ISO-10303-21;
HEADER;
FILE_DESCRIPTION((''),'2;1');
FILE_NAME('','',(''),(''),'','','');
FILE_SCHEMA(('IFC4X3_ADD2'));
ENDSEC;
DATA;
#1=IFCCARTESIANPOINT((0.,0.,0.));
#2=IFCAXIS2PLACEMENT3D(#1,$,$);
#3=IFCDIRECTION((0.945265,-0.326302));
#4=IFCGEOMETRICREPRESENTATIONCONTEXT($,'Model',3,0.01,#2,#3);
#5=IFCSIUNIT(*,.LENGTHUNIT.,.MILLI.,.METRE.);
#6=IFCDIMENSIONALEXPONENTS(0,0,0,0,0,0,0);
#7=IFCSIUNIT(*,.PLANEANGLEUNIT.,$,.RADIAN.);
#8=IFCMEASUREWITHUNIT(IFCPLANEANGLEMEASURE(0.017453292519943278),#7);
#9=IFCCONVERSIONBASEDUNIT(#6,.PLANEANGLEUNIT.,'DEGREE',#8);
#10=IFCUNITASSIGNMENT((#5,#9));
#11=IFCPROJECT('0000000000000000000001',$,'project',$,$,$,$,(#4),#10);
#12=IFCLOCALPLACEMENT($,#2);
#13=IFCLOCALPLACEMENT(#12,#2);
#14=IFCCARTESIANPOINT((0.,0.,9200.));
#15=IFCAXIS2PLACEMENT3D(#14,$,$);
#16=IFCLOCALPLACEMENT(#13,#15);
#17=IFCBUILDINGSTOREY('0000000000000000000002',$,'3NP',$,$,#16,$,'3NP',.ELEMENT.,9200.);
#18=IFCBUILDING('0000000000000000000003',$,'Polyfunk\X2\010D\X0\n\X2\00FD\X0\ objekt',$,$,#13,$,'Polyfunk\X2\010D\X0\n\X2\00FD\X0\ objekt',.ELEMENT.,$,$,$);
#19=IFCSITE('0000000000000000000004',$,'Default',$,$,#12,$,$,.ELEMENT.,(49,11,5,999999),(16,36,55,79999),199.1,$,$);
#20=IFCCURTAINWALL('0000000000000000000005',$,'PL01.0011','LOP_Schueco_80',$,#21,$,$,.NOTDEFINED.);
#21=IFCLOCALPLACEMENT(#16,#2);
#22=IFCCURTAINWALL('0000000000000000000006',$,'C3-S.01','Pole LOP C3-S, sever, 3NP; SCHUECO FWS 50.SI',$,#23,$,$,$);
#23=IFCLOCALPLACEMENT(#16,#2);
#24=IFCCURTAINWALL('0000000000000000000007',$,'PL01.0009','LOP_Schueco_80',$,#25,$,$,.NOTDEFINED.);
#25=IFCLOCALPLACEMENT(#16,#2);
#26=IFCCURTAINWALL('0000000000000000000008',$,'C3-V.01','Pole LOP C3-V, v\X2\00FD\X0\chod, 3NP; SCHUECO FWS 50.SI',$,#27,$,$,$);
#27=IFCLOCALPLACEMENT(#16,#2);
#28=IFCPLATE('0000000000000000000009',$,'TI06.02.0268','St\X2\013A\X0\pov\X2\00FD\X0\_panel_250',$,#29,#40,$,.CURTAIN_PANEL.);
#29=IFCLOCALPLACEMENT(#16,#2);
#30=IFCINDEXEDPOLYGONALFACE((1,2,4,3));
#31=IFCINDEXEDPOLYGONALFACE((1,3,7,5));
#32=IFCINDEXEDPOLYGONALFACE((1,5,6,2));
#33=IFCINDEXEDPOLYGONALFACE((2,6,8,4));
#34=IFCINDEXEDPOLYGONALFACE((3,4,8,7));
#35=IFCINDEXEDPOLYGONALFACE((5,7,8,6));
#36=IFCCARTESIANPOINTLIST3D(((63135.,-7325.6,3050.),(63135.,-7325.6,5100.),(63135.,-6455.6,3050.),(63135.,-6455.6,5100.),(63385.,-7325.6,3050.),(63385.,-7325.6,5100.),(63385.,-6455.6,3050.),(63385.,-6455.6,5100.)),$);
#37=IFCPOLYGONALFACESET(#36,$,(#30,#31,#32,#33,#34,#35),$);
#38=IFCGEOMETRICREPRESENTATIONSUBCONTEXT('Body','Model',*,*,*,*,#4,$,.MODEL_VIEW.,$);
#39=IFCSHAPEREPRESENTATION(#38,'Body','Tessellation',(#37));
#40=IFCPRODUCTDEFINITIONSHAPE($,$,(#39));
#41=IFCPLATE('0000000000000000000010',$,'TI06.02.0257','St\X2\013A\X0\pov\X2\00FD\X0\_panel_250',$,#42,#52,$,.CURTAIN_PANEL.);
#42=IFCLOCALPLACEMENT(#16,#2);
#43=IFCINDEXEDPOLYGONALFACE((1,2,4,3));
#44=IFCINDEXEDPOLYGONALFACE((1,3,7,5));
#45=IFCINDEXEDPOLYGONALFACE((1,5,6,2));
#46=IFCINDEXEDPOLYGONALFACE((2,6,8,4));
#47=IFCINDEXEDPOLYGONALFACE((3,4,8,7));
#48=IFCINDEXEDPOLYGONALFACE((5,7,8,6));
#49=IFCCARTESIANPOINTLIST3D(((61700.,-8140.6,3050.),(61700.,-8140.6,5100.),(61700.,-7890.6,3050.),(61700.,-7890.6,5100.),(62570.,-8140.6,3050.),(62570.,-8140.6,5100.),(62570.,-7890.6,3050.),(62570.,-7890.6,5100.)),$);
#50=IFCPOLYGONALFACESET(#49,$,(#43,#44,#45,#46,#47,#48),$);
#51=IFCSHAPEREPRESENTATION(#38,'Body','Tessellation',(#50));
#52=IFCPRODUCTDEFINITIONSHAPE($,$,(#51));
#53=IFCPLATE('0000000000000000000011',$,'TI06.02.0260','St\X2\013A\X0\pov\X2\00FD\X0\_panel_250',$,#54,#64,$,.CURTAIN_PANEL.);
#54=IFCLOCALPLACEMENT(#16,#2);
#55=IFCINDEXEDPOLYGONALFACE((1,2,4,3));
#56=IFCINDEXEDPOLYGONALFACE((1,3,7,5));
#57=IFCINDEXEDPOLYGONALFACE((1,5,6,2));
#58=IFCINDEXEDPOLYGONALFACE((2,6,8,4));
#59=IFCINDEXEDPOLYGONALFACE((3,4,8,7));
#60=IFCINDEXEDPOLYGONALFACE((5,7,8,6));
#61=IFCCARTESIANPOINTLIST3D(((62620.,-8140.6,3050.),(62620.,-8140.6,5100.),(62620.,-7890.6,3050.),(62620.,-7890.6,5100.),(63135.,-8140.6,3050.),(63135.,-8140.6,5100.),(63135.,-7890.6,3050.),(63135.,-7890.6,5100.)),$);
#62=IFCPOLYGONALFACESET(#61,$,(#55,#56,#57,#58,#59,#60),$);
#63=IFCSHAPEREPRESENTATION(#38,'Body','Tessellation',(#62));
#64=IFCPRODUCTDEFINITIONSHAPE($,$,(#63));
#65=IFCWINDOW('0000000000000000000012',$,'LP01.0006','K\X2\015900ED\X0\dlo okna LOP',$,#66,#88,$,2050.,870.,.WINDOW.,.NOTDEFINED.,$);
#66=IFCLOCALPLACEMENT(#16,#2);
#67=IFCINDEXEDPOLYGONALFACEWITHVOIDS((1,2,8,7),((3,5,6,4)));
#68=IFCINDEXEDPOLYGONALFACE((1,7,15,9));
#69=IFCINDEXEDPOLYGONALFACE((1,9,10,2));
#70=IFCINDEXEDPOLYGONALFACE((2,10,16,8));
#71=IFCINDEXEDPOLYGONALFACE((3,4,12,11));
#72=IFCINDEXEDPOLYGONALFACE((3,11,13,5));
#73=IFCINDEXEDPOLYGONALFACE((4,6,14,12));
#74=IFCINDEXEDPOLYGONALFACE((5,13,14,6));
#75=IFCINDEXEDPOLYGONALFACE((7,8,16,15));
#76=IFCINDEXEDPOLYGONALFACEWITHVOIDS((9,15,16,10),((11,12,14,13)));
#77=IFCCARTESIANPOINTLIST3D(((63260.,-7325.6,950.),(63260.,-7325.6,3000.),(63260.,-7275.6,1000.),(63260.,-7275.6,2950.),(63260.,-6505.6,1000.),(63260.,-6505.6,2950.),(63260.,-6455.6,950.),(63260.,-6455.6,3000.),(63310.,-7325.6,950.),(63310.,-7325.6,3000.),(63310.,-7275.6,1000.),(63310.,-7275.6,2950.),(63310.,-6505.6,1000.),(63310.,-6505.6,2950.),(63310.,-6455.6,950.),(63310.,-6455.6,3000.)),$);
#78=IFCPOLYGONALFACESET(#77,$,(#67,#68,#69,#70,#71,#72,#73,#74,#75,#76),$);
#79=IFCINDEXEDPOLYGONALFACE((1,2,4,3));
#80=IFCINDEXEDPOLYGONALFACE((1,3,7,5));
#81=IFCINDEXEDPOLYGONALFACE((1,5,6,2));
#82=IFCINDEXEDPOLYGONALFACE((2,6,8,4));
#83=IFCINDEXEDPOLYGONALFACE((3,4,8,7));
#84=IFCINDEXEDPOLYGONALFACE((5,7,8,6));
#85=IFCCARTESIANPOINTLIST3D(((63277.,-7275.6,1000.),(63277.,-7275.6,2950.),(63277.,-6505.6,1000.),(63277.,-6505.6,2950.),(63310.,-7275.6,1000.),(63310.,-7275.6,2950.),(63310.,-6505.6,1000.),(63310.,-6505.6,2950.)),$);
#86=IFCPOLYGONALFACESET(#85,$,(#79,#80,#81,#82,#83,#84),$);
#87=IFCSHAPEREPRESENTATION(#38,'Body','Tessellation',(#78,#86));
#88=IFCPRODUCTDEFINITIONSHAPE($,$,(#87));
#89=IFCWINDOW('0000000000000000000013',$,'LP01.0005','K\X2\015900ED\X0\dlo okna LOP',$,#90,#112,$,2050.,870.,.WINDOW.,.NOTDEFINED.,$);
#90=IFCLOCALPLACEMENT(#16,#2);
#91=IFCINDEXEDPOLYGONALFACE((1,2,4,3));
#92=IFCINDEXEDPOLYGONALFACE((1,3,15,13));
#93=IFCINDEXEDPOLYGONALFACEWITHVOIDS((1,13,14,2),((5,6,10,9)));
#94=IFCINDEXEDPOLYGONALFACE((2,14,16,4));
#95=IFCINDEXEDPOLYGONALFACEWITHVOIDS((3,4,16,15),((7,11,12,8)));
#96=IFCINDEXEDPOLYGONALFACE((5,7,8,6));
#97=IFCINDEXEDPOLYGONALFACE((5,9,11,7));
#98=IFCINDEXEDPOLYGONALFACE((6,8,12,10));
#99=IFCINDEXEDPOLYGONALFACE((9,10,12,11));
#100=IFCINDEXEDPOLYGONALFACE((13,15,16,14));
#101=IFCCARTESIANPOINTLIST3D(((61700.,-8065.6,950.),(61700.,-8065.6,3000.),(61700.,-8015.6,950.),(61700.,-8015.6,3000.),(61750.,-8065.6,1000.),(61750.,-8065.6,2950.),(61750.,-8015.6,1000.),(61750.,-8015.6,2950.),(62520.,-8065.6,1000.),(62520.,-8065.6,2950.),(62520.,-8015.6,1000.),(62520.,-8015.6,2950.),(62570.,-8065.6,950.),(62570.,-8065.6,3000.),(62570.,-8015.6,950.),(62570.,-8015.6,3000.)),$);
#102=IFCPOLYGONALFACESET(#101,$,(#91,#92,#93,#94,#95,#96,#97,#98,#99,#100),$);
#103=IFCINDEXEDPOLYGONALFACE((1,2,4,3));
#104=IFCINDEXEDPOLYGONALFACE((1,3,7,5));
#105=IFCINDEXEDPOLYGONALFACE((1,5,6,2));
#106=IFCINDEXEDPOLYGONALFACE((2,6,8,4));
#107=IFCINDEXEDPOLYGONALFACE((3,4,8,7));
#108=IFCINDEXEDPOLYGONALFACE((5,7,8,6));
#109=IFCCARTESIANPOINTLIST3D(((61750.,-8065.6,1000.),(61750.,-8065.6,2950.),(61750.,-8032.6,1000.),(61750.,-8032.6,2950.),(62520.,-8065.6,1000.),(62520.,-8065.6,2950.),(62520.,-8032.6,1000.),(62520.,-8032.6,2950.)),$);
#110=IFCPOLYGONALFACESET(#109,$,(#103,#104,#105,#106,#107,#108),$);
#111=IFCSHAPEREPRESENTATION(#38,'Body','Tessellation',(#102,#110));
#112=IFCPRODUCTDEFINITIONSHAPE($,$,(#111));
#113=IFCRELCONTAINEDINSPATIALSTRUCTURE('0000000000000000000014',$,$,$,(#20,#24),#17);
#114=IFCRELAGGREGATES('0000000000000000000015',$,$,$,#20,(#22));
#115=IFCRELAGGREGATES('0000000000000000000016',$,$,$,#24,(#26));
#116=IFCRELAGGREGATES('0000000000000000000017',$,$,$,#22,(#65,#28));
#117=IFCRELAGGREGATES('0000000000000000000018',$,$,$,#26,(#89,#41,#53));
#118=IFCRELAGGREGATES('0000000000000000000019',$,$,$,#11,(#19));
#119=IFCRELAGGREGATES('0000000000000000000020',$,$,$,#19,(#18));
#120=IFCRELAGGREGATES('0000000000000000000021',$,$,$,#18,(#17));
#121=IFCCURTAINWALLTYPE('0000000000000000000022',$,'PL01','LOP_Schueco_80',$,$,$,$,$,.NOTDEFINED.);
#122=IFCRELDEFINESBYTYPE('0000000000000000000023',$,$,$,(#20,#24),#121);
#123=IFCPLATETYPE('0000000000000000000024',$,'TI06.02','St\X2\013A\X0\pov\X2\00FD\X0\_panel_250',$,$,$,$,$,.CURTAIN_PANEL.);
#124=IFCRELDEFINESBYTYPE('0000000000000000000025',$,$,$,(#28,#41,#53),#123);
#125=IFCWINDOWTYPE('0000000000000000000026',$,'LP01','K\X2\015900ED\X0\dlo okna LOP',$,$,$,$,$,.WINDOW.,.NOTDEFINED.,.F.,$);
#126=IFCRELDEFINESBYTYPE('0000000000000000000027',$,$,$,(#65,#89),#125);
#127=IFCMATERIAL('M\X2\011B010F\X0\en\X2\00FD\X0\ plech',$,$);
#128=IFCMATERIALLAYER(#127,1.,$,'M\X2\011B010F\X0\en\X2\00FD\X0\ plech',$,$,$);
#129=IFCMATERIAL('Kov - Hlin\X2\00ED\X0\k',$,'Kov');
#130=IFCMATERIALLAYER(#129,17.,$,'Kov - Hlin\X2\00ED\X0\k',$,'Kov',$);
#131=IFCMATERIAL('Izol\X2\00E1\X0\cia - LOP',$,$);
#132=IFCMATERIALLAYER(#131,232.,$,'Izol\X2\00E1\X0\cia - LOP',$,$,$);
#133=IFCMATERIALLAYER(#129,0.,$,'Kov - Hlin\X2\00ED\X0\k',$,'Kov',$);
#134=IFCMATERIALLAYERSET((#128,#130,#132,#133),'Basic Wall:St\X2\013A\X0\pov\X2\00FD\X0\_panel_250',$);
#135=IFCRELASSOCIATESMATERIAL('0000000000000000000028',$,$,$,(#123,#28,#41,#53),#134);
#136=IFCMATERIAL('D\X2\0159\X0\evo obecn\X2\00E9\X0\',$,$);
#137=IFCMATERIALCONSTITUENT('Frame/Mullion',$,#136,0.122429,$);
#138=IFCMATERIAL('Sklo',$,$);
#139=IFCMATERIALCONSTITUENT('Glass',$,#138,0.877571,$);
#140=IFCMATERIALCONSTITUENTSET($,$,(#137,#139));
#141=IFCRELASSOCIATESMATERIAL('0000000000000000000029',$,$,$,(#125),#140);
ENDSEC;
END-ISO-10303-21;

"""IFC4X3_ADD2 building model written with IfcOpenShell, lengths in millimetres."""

from ifc_helpers import new_model, entity, si_unit, converted_unit, direction, frame, frame_2d, origin, origin_2d_with_axis, place, context, subcontext, project, spatial, polyline, rectangle, outline, extrude, source, transform, mapped, material, layer, layer_set, layer_usage, constituent, constituent_set, type_object, type_shapes, element, aggregate, save


model = new_model("IFC4X3_ADD2")

# Units and contexts
model_context = context("Model", 3, precision=0.01, world=origin(), true_north=direction((0.945265, -0.326302)))
body_context = subcontext(model_context, "Body", "Model", "MODEL_VIEW")
ifc_project = project(units=[si_unit("LENGTHUNIT", "METRE", prefix="MILLI"), converted_unit("PLANEANGLEUNIT", "DEGREE", entity("IfcPlaneAngleMeasure", 0.017453292519943278), si_unit("PLANEANGLEUNIT", "RADIAN"), dimensions=[0, 0, 0, 0, 0, 0, 0])], contexts=[model_context])

# Site, building, storey
site_placement = place(None, origin())
site = spatial("IfcSite", under=ifc_project, at=site_placement, Name="Default", CompositionType="ELEMENT", RefLatitude=(49, 11, 5, 999999), RefLongitude=(16, 36, 55, 79999), RefElevation=199.1)
building_placement = place(site_placement, origin())
building = spatial("IfcBuilding", under=site, at=building_placement, Name="Polyfunkčný objekt", LongName="Polyfunkčný objekt", CompositionType="ELEMENT")
storey_placement = place(building_placement, frame((0.0, 0.0, 9200.0)))
storey = spatial("IfcBuildingStorey", under=building, at=storey_placement, Name="3NP", LongName="3NP", CompositionType="ELEMENT", Elevation=9200.0)

# Curtain walls
curtain_wall_type = type_object("IfcCurtainWallType", Name="PL01", Description="LOP_Schueco_80", PredefinedType="NOTDEFINED")
curtain_wall_1_placement = place(storey_placement, frame((0.0, 0.0, -9200.0)))
curtain_wall_1 = element("IfcCurtainWall", 1, at=curtain_wall_1_placement, inside=storey, type_object=curtain_wall_type, Name="PL01.0011", Description="LOP_Schueco_80", PredefinedType="NOTDEFINED")
curtain_wall_2 = element("IfcCurtainWall", 2, Name="C3-S.01", Description="Pole LOP C3-S, sever, 3NP; SCHUECO FWS 50.SI")
aggregate(curtain_wall_1, [curtain_wall_2])
curtain_wall_3_placement = place(storey_placement, frame((0.0, 0.0, -9200.0)))
curtain_wall_3 = element("IfcCurtainWall", 3, at=curtain_wall_3_placement, inside=storey, type_object=curtain_wall_type, Name="PL01.0009", Description="LOP_Schueco_80", PredefinedType="NOTDEFINED")
curtain_wall_4 = element("IfcCurtainWall", 4, Name="C3-V.01", Description="Pole LOP C3-V, východ, 3NP; SCHUECO FWS 50.SI")
aggregate(curtain_wall_3, [curtain_wall_4])

# Plates
ifc_material_1 = material(Name="Měďený plech")
ifc_layer_1 = layer(ifc_material_1, 1.0, Name="Měďený plech")
ifc_material_2 = material(Name="Kov - Hliník", Category="Kov")
ifc_layer_2 = layer(ifc_material_2, 17.0, Name="Kov - Hliník", Category="Kov")
ifc_material_3 = material(Name="Izolácia - LOP")
ifc_layer_3 = layer(ifc_material_3, 232.0, Name="Izolácia - LOP")
ifc_layer_4 = layer(ifc_material_2, 0.0, Name="Kov - Hliník", Category="Kov")
ifc_layer_set = layer_set([ifc_layer_1, ifc_layer_2, ifc_layer_3, ifc_layer_4], Name="Basic Wall:Stĺpový_panel_250")
plate_type = type_object("IfcPlateType", Name="TI06.02", Description="Stĺpový_panel_250", PredefinedType="CURTAIN_PANEL", material=ifc_layer_set)
ifc_layer_usage_1 = layer_usage(ifc_layer_set, "AXIS2", "NEGATIVE", 125.0)
plate_1_placement = place(storey_placement, frame((63260.0, -6455.6, 3050.0), z_axis=(0.0, 0.0, 1.0), x_axis=(0.0, -1.0, 0.0)))
plate_1 = element("IfcPlate", 5, at=plate_1_placement, type_object=plate_type, material=ifc_layer_usage_1, Name="TI06.02.0268", Description="Stĺpový_panel_250", PredefinedType="CURTAIN_PANEL", context=body_context, shape_type="SweptSolid", body=[
    extrude(rectangle(XDim=250.0, YDim=870.0, at=frame_2d((0.0, 0.0), x_axis=(1.0, 0.0))), frame((435.0, 0.0, 0.0), z_axis=(0.0, 0.0, 1.0), x_axis=(0.0, 1.0, 0.0)), (0.0, 0.0, 1.0), 2050.0),
])
ifc_layer_usage_2 = layer_usage(ifc_layer_set, "AXIS2", "POSITIVE", -125.0)
plate_2_placement = place(storey_placement, frame((61700.0, -8015.6, 3050.0)))
plate_2 = element("IfcPlate", 6, at=plate_2_placement, type_object=plate_type, material=ifc_layer_usage_2, Name="TI06.02.0257", Description="Stĺpový_panel_250", PredefinedType="CURTAIN_PANEL", context=body_context, shape_type="SweptSolid", body=[
    extrude(rectangle(XDim=250.0, YDim=870.0, at=frame_2d((0.0, 0.0), x_axis=(1.0, 0.0))), frame((435.0, 0.0, 0.0), z_axis=(0.0, 0.0, 1.0), x_axis=(0.0, 1.0, 0.0)), (0.0, 0.0, 1.0), 2050.0),
])
ifc_layer_usage_3 = layer_usage(ifc_layer_set, "AXIS2", "POSITIVE", -125.0)
plate_3_placement = place(storey_placement, frame((62620.0, -8015.6, 3050.0)))
plate_3 = element("IfcPlate", 7, at=plate_3_placement, type_object=plate_type, material=ifc_layer_usage_3, Name="TI06.02.0260", Description="Stĺpový_panel_250", PredefinedType="CURTAIN_PANEL", context=body_context, shape_type="SweptSolid", body=[
    extrude(rectangle(XDim=250.0, YDim=515.0, at=frame_2d((0.0, 0.0), x_axis=(1.0, 0.0))), frame((257.5, 0.0, 0.0), z_axis=(0.0, 0.0, 1.0), x_axis=(0.0, 1.0, 0.0)), (0.0, 0.0, 1.0), 2050.0),
])

# Windows
ifc_material_4 = material(Name="Dřevo obecné")
ifc_constituent_1 = constituent(ifc_material_4, Name="Frame/Mullion", fraction=0.122429)
ifc_material_5 = material(Name="Sklo")
ifc_constituent_2 = constituent(ifc_material_5, Name="Glass", fraction=0.877571)
ifc_constituent_set = constituent_set(constituents=[ifc_constituent_1, ifc_constituent_2])
window_type = type_object("IfcWindowType", Name="LP01", Description="Křídlo okna LOP", ParameterTakesPrecedence=False, PartitioningType="NOTDEFINED", PredefinedType="WINDOW", material=ifc_constituent_set)
shared_shape_1 = source(origin(), body_context, "Body", "SweptSolid", [
    extrude(outline(polyline([(-1025.0, -435.0), (1025.0, -435.0), (1025.0, 435.0), (-1025.0, 435.0), (-1025.0, -435.0)]), holes=[polyline([(-975.0, -385.0), (-975.0, 385.0), (975.0, 385.0), (975.0, -385.0), (-975.0, -385.0)])]), frame((0.0, 0.0, 1025.0), z_axis=(0.0, 1.0, 0.0), x_axis=(0.0, 0.0, -1.0)), (0.0, 0.0, 1.0), 50.0),
    extrude(rectangle(XDim=33.0, YDim=770.0, at=origin_2d_with_axis()), frame((0.0, 33.5, 50.0), z_axis=(0.0, 0.0, 1.0), x_axis=(0.0, -1.0, 0.0)), (0.0, 0.0, 1.0), 1950.0),
])
window_1_placement = place(curtain_wall_1_placement, frame((63260.0, -6890.6, 10150.0), z_axis=(0.0, 0.0, 1.0), x_axis=(0.0, -1.0, 0.0)))
window_1 = element("IfcWindow", 8, at=window_1_placement, type_object=window_type, Name="LP01.0006", Description="Křídlo okna LOP", OverallHeight=2050.0, OverallWidth=870.0, PartitioningType="NOTDEFINED", PredefinedType="WINDOW", context=body_context, shape_type="MappedRepresentation", body=[
    mapped(shared_shape_1, transform((0.0, 0.0, 0.0), scale=1.0)),
])
aggregate(curtain_wall_2, [window_1, plate_1])
shared_shape_2 = source(origin(), body_context, "Body", "SweptSolid", [
    extrude(outline(polyline([(-1025.0, -435.0), (1025.0, -435.0), (1025.0, 435.0), (-1025.0, 435.0), (-1025.0, -435.0)]), holes=[polyline([(-975.0, -385.0), (-975.0, 385.0), (975.0, 385.0), (975.0, -385.0), (-975.0, -385.0)])]), frame((0.0, 50.0, 1025.0), z_axis=(0.0, -1.0, 0.0), x_axis=(0.0, 0.0, -1.0)), (0.0, 0.0, 1.0), 50.0),
    extrude(rectangle(XDim=770.0, YDim=33.0, at=frame_2d((0.0, 0.0), x_axis=(1.0, 0.0))), frame((0.0, 33.5, 50.0), z_axis=(0.0, 0.0, 1.0), x_axis=(-1.0, 0.0, 0.0)), (0.0, 0.0, 1.0), 1950.0),
])
type_shapes(window_type, [shared_shape_1, shared_shape_2])
window_2_placement = place(curtain_wall_3_placement, frame((62135.0, -8015.6, 10150.0), z_axis=(0.0, 0.0, 1.0), x_axis=(-1.0, 0.0, 0.0)))
window_2 = element("IfcWindow", 9, at=window_2_placement, type_object=window_type, Name="LP01.0005", Description="Křídlo okna LOP", OverallHeight=2050.0, OverallWidth=870.0, PartitioningType="NOTDEFINED", PredefinedType="WINDOW", context=body_context, shape_type="MappedRepresentation", body=[
    mapped(shared_shape_2, transform((0.0, 0.0, 0.0), scale=1.0)),
])
aggregate(curtain_wall_4, [window_2, plate_2, plate_3])

save(model, "model.ifc")
